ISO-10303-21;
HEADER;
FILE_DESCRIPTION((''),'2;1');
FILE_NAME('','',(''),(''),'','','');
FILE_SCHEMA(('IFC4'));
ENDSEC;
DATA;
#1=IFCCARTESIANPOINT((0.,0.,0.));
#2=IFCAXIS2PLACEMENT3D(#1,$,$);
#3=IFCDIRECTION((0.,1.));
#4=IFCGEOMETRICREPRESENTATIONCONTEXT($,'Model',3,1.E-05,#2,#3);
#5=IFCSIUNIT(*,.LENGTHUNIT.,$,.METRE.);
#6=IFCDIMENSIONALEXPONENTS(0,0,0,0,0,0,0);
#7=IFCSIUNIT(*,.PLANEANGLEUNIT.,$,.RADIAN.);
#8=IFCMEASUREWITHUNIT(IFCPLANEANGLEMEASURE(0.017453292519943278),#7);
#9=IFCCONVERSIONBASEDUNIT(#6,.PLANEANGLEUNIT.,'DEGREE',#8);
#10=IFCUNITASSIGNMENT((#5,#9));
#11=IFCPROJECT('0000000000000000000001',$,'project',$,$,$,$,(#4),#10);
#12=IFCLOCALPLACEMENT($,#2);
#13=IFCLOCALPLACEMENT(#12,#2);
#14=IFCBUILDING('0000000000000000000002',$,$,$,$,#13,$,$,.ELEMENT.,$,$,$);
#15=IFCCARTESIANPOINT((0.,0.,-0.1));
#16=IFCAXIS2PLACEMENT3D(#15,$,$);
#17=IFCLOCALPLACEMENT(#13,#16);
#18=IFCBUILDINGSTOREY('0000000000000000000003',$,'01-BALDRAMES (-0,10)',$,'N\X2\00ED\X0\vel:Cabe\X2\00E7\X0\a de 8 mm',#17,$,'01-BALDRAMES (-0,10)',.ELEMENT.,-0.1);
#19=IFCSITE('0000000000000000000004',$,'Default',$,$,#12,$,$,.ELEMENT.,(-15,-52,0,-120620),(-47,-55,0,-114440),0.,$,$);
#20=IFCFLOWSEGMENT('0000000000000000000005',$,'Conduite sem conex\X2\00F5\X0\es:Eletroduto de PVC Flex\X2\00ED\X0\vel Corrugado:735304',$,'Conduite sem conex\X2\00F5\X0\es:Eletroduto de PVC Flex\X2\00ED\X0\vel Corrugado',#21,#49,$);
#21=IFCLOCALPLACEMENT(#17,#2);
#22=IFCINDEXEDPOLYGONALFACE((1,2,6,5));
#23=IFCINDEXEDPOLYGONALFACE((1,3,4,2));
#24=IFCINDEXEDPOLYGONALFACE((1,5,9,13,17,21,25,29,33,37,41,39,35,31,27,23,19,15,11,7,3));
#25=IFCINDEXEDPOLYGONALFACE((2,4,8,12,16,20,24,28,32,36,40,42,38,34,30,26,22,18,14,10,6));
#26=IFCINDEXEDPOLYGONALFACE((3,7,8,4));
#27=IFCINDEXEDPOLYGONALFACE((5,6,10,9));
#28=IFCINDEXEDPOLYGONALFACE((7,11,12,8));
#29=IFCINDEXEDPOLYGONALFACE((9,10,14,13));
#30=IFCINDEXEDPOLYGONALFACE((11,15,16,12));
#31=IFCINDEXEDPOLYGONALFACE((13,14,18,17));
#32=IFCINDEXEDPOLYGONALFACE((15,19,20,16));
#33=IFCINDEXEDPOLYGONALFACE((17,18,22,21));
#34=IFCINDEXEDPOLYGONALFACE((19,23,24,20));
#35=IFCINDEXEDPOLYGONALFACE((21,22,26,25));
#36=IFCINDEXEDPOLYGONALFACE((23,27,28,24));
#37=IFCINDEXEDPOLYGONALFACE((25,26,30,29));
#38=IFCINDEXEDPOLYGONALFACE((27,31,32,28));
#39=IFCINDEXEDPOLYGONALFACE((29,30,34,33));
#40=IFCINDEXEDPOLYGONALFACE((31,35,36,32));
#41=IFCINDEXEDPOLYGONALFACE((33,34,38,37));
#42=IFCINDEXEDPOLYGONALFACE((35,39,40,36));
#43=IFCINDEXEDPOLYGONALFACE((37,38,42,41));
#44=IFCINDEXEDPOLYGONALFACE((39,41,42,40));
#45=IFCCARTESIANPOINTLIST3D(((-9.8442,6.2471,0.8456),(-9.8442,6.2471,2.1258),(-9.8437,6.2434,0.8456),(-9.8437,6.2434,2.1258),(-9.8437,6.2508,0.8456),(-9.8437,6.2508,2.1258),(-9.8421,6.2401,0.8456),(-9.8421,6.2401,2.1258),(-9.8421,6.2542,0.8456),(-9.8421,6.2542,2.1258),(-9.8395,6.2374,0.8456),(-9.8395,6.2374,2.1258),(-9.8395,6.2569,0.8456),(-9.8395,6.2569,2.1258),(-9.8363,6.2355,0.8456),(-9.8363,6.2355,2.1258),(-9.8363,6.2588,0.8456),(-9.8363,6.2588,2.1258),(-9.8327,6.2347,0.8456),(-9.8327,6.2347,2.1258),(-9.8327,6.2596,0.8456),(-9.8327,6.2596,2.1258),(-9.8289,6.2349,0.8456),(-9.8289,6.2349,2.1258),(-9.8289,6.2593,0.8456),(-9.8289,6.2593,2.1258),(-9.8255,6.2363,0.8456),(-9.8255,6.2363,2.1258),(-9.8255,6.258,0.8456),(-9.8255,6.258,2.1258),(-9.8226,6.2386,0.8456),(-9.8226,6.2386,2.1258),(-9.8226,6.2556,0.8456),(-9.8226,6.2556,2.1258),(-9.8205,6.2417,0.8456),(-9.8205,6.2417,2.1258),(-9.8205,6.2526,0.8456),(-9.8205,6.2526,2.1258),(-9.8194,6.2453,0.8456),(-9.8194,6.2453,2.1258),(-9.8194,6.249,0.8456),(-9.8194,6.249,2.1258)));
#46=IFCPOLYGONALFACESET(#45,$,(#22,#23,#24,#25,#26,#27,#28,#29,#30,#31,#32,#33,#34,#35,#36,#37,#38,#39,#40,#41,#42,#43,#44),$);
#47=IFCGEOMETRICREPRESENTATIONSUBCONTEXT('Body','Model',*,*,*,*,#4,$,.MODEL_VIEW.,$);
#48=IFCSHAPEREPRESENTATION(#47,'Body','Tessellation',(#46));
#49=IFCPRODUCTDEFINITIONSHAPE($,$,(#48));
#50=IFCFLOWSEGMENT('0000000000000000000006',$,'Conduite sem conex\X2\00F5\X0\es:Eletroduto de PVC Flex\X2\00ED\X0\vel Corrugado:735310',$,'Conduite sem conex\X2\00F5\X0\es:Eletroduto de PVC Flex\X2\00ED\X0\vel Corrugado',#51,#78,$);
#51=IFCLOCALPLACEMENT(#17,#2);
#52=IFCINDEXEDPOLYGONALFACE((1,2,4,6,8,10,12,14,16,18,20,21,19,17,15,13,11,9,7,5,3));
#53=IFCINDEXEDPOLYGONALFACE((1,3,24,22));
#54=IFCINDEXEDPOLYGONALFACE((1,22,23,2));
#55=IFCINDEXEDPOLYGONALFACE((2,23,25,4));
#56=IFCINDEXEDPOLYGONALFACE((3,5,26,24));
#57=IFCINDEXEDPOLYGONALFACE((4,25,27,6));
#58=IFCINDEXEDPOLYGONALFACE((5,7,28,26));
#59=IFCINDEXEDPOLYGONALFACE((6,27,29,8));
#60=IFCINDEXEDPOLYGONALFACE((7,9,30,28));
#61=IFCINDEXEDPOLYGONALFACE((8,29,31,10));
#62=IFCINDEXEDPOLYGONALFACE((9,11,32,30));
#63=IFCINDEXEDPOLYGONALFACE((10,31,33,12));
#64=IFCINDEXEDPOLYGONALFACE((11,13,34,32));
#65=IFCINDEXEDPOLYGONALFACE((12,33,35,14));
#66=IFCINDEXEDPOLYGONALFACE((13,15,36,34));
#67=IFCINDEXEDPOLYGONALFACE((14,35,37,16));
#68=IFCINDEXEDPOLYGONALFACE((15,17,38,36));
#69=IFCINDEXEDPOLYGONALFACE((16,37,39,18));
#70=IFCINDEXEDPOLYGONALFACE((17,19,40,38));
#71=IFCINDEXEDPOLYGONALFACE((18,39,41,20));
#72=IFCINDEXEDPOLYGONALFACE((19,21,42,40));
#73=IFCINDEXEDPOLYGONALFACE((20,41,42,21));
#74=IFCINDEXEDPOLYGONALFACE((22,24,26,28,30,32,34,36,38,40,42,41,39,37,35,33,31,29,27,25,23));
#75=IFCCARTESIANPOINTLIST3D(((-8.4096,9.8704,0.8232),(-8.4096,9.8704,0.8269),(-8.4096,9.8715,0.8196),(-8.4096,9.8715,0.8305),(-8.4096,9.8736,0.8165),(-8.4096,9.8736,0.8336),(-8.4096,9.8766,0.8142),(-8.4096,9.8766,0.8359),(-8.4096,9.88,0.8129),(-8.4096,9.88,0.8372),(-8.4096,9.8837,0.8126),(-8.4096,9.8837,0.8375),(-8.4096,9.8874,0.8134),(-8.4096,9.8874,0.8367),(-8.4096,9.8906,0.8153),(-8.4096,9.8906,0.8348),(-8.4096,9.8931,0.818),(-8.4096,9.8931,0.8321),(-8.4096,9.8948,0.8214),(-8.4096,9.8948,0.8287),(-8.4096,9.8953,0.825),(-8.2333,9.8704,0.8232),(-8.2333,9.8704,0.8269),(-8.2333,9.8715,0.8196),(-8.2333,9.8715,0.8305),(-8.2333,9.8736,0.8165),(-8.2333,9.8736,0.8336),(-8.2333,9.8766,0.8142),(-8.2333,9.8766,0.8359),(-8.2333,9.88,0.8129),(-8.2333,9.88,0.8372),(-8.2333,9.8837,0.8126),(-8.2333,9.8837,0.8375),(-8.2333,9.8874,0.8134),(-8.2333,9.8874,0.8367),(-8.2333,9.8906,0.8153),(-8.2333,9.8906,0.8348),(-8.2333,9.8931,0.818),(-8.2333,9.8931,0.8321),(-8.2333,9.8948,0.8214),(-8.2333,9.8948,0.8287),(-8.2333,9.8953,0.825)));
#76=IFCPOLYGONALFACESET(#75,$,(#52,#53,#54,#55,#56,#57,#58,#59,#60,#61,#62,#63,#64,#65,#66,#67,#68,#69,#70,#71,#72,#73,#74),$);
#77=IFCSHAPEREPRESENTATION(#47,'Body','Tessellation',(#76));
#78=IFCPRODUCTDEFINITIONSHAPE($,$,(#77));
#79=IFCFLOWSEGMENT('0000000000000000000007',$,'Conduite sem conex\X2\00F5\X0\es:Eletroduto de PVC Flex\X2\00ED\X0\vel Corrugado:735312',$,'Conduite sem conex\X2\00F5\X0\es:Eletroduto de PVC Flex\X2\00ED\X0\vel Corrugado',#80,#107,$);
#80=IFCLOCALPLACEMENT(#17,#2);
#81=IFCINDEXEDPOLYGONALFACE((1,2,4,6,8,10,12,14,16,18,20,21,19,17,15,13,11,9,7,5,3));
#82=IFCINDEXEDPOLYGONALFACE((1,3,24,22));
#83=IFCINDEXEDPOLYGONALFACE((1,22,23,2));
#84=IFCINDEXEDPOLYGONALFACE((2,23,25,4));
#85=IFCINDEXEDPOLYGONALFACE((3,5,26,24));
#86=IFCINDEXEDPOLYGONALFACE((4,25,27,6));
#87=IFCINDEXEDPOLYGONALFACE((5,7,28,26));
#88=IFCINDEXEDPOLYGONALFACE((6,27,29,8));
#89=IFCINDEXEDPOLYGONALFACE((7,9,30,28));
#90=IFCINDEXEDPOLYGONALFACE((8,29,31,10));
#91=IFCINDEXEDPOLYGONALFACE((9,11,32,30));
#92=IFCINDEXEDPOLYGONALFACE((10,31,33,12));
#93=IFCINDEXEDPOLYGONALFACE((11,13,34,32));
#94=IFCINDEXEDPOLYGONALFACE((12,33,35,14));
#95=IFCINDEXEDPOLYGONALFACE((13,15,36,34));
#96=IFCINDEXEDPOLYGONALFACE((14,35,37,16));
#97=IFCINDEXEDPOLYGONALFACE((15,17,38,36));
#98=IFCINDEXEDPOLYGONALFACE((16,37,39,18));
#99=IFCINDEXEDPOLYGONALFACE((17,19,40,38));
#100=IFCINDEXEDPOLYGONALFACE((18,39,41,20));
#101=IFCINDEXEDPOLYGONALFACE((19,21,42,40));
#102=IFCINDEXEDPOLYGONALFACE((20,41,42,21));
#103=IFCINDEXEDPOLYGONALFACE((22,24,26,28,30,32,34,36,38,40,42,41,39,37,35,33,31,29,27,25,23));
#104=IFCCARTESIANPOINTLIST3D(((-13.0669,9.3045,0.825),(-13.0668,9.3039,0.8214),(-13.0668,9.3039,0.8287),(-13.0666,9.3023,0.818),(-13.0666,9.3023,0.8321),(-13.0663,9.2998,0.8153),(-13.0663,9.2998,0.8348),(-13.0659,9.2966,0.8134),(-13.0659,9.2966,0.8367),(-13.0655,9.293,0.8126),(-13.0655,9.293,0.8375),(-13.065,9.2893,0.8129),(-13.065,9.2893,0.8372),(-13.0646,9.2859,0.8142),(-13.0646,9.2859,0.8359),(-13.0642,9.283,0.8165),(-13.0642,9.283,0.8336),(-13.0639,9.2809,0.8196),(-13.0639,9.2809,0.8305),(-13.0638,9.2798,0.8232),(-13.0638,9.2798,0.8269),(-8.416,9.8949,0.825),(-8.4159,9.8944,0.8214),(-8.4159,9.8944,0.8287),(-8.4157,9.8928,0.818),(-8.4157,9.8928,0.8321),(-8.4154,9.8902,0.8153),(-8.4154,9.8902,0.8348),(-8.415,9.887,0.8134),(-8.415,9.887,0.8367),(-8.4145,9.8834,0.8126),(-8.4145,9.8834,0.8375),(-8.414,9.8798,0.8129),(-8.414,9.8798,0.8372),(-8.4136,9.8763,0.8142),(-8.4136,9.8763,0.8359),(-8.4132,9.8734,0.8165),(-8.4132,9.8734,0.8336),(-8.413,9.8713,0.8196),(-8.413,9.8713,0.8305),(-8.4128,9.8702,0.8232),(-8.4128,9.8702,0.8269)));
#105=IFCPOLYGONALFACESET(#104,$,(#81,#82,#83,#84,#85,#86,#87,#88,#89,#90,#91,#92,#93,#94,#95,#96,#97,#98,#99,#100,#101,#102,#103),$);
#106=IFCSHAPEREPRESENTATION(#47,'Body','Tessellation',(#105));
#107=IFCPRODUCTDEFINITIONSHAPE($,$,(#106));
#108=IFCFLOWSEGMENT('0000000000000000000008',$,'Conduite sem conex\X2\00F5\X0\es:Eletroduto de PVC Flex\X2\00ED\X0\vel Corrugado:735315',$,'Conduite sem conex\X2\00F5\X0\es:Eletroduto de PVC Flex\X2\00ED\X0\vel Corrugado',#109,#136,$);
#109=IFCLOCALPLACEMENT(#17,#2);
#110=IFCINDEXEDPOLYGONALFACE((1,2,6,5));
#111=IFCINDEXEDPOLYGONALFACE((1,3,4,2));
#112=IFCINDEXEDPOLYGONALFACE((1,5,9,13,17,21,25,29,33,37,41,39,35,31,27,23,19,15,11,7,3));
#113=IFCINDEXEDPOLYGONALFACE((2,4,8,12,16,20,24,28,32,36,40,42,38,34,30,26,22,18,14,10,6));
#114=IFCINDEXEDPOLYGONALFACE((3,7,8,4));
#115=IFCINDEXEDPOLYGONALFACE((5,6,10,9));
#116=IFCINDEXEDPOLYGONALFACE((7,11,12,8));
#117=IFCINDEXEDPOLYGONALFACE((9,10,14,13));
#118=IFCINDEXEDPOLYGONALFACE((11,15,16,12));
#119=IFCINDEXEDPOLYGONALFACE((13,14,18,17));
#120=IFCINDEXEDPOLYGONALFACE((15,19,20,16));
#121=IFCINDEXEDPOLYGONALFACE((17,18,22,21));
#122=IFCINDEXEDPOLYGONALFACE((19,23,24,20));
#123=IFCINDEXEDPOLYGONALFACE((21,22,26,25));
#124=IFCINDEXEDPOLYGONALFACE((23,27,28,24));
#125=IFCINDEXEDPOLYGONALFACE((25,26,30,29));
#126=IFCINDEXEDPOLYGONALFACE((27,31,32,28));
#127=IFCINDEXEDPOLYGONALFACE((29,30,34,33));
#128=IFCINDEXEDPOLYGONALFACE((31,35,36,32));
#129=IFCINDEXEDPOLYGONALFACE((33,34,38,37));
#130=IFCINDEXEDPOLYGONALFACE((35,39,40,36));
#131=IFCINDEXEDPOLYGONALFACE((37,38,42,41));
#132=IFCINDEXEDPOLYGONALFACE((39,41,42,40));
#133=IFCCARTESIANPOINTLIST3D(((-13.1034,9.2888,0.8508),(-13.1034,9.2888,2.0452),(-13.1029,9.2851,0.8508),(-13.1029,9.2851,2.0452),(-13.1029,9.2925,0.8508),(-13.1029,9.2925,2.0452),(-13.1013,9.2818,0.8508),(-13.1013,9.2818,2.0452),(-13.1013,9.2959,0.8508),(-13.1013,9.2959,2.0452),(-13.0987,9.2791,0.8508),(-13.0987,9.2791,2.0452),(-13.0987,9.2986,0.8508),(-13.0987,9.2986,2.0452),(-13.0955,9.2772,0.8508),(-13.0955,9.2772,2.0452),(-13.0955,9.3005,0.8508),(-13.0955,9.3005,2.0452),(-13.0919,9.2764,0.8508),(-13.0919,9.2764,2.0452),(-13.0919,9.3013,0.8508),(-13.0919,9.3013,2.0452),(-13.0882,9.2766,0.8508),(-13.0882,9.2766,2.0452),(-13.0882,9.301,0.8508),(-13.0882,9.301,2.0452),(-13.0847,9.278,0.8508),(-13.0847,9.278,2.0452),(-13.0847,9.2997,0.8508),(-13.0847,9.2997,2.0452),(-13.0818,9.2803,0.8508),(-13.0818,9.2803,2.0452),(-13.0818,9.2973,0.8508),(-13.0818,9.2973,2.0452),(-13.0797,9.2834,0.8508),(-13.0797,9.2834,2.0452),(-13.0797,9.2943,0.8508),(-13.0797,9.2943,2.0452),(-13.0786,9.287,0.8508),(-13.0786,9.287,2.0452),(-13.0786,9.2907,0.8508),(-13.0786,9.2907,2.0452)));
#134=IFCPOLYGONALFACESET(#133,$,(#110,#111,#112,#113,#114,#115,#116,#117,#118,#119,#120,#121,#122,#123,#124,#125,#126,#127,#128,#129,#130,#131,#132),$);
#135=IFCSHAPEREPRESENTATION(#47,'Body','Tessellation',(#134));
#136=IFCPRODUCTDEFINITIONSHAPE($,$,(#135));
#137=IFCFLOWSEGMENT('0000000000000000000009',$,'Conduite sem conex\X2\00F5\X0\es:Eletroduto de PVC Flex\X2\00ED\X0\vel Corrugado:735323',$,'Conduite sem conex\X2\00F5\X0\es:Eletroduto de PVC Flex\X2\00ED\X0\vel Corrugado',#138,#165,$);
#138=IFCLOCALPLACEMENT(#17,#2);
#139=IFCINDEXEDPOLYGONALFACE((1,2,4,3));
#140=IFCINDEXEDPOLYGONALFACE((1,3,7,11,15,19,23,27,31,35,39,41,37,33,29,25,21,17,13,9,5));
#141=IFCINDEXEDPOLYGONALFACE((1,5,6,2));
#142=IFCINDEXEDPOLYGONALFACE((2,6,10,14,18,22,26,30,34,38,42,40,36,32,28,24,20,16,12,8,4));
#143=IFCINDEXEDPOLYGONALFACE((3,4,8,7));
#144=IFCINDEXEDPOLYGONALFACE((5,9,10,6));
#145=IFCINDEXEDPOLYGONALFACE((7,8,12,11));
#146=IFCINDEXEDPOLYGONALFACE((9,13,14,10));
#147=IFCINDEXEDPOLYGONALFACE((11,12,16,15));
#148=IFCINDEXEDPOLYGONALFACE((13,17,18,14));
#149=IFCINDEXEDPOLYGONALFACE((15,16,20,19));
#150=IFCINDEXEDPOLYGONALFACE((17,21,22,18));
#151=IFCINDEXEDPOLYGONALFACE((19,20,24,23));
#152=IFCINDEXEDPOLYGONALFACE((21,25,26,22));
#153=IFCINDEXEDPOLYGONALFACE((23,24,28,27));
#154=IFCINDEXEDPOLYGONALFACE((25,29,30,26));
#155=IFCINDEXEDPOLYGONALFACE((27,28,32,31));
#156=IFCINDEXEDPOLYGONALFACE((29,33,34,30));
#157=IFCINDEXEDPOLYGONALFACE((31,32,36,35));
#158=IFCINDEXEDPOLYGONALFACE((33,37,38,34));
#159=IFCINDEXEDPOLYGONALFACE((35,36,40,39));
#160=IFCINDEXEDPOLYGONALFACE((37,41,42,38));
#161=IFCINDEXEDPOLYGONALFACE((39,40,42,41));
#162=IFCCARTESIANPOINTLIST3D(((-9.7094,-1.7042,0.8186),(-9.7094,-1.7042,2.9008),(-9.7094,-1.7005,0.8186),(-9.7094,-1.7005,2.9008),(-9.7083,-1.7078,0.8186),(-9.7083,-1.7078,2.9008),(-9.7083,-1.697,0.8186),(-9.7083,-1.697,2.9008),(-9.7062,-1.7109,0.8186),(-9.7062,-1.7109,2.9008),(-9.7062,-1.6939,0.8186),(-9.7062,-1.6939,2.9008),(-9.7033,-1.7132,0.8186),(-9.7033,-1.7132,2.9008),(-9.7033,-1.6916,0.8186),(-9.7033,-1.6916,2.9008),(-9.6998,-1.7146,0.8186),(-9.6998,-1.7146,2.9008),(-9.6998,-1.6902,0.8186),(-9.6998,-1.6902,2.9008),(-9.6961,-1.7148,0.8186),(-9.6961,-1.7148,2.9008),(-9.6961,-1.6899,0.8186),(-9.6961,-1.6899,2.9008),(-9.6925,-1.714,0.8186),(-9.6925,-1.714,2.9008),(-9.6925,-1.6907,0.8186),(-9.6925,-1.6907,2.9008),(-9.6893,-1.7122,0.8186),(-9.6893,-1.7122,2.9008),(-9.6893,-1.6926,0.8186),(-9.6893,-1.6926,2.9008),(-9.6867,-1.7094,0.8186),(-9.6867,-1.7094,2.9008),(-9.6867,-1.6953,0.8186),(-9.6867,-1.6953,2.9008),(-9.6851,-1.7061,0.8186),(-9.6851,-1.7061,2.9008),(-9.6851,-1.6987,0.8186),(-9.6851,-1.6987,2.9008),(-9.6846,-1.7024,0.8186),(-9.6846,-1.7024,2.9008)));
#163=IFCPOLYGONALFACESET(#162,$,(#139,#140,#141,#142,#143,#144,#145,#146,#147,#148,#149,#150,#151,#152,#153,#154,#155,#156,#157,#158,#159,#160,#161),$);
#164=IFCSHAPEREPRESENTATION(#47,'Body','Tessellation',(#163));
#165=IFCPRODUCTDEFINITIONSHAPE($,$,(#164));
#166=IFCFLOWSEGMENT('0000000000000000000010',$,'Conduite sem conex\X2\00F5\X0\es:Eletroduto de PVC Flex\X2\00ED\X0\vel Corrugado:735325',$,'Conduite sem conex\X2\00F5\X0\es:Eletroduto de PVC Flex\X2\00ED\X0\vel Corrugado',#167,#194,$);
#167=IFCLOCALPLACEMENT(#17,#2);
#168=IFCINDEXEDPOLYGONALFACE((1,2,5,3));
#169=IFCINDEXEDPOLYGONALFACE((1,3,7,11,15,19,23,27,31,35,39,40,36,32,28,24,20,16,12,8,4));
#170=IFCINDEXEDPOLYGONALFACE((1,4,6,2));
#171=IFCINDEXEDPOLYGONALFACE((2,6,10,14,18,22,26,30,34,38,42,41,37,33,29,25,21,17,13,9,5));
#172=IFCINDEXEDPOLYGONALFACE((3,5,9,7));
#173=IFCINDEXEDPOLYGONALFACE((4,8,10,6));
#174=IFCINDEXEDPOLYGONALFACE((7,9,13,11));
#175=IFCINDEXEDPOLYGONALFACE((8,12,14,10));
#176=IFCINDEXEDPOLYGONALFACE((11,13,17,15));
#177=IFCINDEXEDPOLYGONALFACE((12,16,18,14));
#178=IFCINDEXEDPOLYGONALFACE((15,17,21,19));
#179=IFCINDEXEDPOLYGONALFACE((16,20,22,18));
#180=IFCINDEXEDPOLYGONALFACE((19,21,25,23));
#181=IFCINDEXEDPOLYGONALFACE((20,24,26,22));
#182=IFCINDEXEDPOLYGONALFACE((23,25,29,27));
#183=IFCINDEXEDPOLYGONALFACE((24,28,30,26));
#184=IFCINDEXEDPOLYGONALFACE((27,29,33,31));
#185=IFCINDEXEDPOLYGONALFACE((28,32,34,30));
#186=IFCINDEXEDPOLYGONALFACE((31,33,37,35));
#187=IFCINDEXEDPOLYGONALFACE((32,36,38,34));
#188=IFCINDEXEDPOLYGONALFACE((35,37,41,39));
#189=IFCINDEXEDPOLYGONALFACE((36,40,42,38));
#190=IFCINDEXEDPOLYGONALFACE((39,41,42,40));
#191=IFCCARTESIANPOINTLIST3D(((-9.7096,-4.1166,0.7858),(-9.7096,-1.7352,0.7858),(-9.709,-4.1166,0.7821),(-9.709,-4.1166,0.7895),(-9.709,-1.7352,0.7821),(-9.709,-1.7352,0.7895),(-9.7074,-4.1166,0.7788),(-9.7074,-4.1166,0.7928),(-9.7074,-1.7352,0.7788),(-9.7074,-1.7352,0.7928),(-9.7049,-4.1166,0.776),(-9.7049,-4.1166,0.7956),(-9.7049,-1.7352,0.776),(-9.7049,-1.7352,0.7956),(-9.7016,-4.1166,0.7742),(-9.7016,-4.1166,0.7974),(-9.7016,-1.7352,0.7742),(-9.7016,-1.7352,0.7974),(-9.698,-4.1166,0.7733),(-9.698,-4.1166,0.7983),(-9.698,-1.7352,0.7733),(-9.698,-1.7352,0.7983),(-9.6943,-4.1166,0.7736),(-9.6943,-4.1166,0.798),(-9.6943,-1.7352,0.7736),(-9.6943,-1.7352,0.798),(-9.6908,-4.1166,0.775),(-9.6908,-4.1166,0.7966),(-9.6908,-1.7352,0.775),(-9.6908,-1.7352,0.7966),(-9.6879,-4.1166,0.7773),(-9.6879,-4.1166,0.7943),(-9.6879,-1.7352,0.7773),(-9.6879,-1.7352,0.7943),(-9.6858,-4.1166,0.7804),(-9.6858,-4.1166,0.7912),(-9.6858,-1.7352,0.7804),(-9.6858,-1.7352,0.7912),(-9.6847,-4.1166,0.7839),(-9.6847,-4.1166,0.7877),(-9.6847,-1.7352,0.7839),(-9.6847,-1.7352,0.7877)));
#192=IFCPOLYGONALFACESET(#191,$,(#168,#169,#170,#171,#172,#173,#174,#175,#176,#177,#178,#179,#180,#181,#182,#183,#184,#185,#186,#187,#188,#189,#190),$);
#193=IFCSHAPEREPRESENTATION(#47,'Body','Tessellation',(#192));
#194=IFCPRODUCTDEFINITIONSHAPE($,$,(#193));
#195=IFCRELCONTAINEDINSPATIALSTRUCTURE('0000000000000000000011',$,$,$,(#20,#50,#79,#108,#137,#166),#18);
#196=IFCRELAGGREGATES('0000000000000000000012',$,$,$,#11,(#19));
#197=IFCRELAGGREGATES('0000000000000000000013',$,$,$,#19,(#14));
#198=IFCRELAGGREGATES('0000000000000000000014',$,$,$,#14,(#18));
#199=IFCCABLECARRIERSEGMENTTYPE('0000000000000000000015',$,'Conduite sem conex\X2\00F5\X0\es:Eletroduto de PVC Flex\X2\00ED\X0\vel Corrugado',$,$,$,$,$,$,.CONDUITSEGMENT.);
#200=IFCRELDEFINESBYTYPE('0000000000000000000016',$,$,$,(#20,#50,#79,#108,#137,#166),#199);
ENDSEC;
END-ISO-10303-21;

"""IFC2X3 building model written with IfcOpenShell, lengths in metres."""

from ifc_helpers import new_model, entity, si_unit, converted_unit, direction, frame, frame_2d, origin, origin_2d_with_axis, place, context, subcontext, project, spatial, circle, extrude, type_object, element, save


model = new_model("IFC2X3")

# Units and contexts
model_context = context("Model", 3, precision=1e-05, world=origin(), true_north=direction((0.0, 1.0)))
body_context = subcontext(model_context, "Body", "Model", "MODEL_VIEW")
ifc_project = project(units=[si_unit("LENGTHUNIT", "METRE"), converted_unit("PLANEANGLEUNIT", "DEGREE", entity("IfcPlaneAngleMeasure", 0.017453292519943278), si_unit("PLANEANGLEUNIT", "RADIAN"), dimensions=[0, 0, 0, 0, 0, 0, 0])], contexts=[model_context])

# Site, building, storey
site_placement = place(None, origin())
site = spatial("IfcSite", under=ifc_project, at=site_placement, Name="Default", CompositionType="ELEMENT", RefLatitude=(-15, -52, 0, -120620), RefLongitude=(-47, -55, 0, -114440), RefElevation=0.0)
building_placement = place(site_placement, origin())
building = spatial("IfcBuilding", under=site, at=building_placement, CompositionType="ELEMENT")
storey_placement = place(building_placement, frame((0.0, 0.0, -0.1)))
storey = spatial("IfcBuildingStorey", under=building, at=storey_placement, Name="01-BALDRAMES (-0,10)", ObjectType="Nível:Cabeça de 8 mm", LongName="01-BALDRAMES (-0,10)", CompositionType="ELEMENT", Elevation=-0.1)

# Flow segments
cable_carrier_segment_type = type_object("IfcCableCarrierSegmentType", Name="Conduite sem conexões:Eletroduto de PVC Flexível Corrugado", PredefinedType="CONDUITSEGMENT")
flow_segment_1_placement = place(storey_placement, origin())
element("IfcFlowSegment", 1, at=flow_segment_1_placement, inside=storey, type_object=cable_carrier_segment_type, Name="Conduite sem conexões:Eletroduto de PVC Flexível Corrugado:735304", ObjectType="Conduite sem conexões:Eletroduto de PVC Flexível Corrugado", context=body_context, shape_type="SweptSolid", body=[
    extrude(circle(Radius=0.0125, at=frame_2d((0.0, 0.0), x_axis=(1.0, 0.0))), frame((-9.8317, 6.2471, 0.8456), z_axis=(0.0, 0.0, 1.0), x_axis=(-1.0, 0.0, 0.0)), (0.0, 0.0, 1.0), 1.2802),
])
flow_segment_2_placement = place(storey_placement, origin())
element("IfcFlowSegment", 2, at=flow_segment_2_placement, inside=storey, type_object=cable_carrier_segment_type, Name="Conduite sem conexões:Eletroduto de PVC Flexível Corrugado:735310", ObjectType="Conduite sem conexões:Eletroduto de PVC Flexível Corrugado", context=body_context, shape_type="SweptSolid", body=[
    extrude(circle(Radius=0.0125, at=origin_2d_with_axis()), frame((-8.4096, 9.8828, 0.825), z_axis=(1.0, 0.0, 0.0), x_axis=(0.0, 1.0, 0.0)), (0.0, 0.0, 1.0), 0.1764),
])
flow_segment_3_placement = place(storey_placement, origin())
element("IfcFlowSegment", 3, at=flow_segment_3_placement, inside=storey, type_object=cable_carrier_segment_type, Name="Conduite sem conexões:Eletroduto de PVC Flexível Corrugado:735312", ObjectType="Conduite sem conexões:Eletroduto de PVC Flexível Corrugado", context=body_context, shape_type="SweptSolid", body=[
    extrude(circle(Radius=0.0125, at=frame_2d((0.0, 0.0), x_axis=(1.0, 0.0))), frame((-13.0653, 9.2921, 0.825), z_axis=(0.992038, 0.125938, 0.0), x_axis=(-0.125938, 0.992038, 0.0)), (0.0, 0.0, 1.0), 4.6883),
])
flow_segment_4_placement = place(storey_placement, origin())
element("IfcFlowSegment", 4, at=flow_segment_4_placement, inside=storey, type_object=cable_carrier_segment_type, Name="Conduite sem conexões:Eletroduto de PVC Flexível Corrugado:735315", ObjectType="Conduite sem conexões:Eletroduto de PVC Flexível Corrugado", context=body_context, shape_type="SweptSolid", body=[
    extrude(circle(Radius=0.0125, at=frame_2d((0.0, 0.0), x_axis=(1.0, 0.0))), frame((-13.0909, 9.2888, 0.8508), z_axis=(0.0, 0.0, 1.0), x_axis=(-1.0, 0.0, 0.0)), (0.0, 0.0, 1.0), 1.1943),
])
flow_segment_5_placement = place(storey_placement, origin())
element("IfcFlowSegment", 5, at=flow_segment_5_placement, inside=storey, type_object=cable_carrier_segment_type, Name="Conduite sem conexões:Eletroduto de PVC Flexível Corrugado:735323", ObjectType="Conduite sem conexões:Eletroduto de PVC Flexível Corrugado", context=body_context, shape_type="SweptSolid", body=[
    extrude(circle(Radius=0.0125, at=origin_2d_with_axis()), frame((-9.6971, -1.7024, 0.8186)), (0.0, 0.0, 1.0), 2.0822),
])
flow_segment_6_placement = place(storey_placement, origin())
element("IfcFlowSegment", 6, at=flow_segment_6_placement, inside=storey, type_object=cable_carrier_segment_type, Name="Conduite sem conexões:Eletroduto de PVC Flexível Corrugado:735325", ObjectType="Conduite sem conexões:Eletroduto de PVC Flexível Corrugado", context=body_context, shape_type="SweptSolid", body=[
    extrude(circle(Radius=0.0125, at=frame_2d((0.0, 0.0), x_axis=(1.0, 0.0))), frame((-9.6971, -4.1166, 0.7858), z_axis=(0.0, 1.0, 0.0), x_axis=(-1.0, 0.0, 0.0)), (0.0, 0.0, 1.0), 2.3814),
])

save(model, "model.ifc")
